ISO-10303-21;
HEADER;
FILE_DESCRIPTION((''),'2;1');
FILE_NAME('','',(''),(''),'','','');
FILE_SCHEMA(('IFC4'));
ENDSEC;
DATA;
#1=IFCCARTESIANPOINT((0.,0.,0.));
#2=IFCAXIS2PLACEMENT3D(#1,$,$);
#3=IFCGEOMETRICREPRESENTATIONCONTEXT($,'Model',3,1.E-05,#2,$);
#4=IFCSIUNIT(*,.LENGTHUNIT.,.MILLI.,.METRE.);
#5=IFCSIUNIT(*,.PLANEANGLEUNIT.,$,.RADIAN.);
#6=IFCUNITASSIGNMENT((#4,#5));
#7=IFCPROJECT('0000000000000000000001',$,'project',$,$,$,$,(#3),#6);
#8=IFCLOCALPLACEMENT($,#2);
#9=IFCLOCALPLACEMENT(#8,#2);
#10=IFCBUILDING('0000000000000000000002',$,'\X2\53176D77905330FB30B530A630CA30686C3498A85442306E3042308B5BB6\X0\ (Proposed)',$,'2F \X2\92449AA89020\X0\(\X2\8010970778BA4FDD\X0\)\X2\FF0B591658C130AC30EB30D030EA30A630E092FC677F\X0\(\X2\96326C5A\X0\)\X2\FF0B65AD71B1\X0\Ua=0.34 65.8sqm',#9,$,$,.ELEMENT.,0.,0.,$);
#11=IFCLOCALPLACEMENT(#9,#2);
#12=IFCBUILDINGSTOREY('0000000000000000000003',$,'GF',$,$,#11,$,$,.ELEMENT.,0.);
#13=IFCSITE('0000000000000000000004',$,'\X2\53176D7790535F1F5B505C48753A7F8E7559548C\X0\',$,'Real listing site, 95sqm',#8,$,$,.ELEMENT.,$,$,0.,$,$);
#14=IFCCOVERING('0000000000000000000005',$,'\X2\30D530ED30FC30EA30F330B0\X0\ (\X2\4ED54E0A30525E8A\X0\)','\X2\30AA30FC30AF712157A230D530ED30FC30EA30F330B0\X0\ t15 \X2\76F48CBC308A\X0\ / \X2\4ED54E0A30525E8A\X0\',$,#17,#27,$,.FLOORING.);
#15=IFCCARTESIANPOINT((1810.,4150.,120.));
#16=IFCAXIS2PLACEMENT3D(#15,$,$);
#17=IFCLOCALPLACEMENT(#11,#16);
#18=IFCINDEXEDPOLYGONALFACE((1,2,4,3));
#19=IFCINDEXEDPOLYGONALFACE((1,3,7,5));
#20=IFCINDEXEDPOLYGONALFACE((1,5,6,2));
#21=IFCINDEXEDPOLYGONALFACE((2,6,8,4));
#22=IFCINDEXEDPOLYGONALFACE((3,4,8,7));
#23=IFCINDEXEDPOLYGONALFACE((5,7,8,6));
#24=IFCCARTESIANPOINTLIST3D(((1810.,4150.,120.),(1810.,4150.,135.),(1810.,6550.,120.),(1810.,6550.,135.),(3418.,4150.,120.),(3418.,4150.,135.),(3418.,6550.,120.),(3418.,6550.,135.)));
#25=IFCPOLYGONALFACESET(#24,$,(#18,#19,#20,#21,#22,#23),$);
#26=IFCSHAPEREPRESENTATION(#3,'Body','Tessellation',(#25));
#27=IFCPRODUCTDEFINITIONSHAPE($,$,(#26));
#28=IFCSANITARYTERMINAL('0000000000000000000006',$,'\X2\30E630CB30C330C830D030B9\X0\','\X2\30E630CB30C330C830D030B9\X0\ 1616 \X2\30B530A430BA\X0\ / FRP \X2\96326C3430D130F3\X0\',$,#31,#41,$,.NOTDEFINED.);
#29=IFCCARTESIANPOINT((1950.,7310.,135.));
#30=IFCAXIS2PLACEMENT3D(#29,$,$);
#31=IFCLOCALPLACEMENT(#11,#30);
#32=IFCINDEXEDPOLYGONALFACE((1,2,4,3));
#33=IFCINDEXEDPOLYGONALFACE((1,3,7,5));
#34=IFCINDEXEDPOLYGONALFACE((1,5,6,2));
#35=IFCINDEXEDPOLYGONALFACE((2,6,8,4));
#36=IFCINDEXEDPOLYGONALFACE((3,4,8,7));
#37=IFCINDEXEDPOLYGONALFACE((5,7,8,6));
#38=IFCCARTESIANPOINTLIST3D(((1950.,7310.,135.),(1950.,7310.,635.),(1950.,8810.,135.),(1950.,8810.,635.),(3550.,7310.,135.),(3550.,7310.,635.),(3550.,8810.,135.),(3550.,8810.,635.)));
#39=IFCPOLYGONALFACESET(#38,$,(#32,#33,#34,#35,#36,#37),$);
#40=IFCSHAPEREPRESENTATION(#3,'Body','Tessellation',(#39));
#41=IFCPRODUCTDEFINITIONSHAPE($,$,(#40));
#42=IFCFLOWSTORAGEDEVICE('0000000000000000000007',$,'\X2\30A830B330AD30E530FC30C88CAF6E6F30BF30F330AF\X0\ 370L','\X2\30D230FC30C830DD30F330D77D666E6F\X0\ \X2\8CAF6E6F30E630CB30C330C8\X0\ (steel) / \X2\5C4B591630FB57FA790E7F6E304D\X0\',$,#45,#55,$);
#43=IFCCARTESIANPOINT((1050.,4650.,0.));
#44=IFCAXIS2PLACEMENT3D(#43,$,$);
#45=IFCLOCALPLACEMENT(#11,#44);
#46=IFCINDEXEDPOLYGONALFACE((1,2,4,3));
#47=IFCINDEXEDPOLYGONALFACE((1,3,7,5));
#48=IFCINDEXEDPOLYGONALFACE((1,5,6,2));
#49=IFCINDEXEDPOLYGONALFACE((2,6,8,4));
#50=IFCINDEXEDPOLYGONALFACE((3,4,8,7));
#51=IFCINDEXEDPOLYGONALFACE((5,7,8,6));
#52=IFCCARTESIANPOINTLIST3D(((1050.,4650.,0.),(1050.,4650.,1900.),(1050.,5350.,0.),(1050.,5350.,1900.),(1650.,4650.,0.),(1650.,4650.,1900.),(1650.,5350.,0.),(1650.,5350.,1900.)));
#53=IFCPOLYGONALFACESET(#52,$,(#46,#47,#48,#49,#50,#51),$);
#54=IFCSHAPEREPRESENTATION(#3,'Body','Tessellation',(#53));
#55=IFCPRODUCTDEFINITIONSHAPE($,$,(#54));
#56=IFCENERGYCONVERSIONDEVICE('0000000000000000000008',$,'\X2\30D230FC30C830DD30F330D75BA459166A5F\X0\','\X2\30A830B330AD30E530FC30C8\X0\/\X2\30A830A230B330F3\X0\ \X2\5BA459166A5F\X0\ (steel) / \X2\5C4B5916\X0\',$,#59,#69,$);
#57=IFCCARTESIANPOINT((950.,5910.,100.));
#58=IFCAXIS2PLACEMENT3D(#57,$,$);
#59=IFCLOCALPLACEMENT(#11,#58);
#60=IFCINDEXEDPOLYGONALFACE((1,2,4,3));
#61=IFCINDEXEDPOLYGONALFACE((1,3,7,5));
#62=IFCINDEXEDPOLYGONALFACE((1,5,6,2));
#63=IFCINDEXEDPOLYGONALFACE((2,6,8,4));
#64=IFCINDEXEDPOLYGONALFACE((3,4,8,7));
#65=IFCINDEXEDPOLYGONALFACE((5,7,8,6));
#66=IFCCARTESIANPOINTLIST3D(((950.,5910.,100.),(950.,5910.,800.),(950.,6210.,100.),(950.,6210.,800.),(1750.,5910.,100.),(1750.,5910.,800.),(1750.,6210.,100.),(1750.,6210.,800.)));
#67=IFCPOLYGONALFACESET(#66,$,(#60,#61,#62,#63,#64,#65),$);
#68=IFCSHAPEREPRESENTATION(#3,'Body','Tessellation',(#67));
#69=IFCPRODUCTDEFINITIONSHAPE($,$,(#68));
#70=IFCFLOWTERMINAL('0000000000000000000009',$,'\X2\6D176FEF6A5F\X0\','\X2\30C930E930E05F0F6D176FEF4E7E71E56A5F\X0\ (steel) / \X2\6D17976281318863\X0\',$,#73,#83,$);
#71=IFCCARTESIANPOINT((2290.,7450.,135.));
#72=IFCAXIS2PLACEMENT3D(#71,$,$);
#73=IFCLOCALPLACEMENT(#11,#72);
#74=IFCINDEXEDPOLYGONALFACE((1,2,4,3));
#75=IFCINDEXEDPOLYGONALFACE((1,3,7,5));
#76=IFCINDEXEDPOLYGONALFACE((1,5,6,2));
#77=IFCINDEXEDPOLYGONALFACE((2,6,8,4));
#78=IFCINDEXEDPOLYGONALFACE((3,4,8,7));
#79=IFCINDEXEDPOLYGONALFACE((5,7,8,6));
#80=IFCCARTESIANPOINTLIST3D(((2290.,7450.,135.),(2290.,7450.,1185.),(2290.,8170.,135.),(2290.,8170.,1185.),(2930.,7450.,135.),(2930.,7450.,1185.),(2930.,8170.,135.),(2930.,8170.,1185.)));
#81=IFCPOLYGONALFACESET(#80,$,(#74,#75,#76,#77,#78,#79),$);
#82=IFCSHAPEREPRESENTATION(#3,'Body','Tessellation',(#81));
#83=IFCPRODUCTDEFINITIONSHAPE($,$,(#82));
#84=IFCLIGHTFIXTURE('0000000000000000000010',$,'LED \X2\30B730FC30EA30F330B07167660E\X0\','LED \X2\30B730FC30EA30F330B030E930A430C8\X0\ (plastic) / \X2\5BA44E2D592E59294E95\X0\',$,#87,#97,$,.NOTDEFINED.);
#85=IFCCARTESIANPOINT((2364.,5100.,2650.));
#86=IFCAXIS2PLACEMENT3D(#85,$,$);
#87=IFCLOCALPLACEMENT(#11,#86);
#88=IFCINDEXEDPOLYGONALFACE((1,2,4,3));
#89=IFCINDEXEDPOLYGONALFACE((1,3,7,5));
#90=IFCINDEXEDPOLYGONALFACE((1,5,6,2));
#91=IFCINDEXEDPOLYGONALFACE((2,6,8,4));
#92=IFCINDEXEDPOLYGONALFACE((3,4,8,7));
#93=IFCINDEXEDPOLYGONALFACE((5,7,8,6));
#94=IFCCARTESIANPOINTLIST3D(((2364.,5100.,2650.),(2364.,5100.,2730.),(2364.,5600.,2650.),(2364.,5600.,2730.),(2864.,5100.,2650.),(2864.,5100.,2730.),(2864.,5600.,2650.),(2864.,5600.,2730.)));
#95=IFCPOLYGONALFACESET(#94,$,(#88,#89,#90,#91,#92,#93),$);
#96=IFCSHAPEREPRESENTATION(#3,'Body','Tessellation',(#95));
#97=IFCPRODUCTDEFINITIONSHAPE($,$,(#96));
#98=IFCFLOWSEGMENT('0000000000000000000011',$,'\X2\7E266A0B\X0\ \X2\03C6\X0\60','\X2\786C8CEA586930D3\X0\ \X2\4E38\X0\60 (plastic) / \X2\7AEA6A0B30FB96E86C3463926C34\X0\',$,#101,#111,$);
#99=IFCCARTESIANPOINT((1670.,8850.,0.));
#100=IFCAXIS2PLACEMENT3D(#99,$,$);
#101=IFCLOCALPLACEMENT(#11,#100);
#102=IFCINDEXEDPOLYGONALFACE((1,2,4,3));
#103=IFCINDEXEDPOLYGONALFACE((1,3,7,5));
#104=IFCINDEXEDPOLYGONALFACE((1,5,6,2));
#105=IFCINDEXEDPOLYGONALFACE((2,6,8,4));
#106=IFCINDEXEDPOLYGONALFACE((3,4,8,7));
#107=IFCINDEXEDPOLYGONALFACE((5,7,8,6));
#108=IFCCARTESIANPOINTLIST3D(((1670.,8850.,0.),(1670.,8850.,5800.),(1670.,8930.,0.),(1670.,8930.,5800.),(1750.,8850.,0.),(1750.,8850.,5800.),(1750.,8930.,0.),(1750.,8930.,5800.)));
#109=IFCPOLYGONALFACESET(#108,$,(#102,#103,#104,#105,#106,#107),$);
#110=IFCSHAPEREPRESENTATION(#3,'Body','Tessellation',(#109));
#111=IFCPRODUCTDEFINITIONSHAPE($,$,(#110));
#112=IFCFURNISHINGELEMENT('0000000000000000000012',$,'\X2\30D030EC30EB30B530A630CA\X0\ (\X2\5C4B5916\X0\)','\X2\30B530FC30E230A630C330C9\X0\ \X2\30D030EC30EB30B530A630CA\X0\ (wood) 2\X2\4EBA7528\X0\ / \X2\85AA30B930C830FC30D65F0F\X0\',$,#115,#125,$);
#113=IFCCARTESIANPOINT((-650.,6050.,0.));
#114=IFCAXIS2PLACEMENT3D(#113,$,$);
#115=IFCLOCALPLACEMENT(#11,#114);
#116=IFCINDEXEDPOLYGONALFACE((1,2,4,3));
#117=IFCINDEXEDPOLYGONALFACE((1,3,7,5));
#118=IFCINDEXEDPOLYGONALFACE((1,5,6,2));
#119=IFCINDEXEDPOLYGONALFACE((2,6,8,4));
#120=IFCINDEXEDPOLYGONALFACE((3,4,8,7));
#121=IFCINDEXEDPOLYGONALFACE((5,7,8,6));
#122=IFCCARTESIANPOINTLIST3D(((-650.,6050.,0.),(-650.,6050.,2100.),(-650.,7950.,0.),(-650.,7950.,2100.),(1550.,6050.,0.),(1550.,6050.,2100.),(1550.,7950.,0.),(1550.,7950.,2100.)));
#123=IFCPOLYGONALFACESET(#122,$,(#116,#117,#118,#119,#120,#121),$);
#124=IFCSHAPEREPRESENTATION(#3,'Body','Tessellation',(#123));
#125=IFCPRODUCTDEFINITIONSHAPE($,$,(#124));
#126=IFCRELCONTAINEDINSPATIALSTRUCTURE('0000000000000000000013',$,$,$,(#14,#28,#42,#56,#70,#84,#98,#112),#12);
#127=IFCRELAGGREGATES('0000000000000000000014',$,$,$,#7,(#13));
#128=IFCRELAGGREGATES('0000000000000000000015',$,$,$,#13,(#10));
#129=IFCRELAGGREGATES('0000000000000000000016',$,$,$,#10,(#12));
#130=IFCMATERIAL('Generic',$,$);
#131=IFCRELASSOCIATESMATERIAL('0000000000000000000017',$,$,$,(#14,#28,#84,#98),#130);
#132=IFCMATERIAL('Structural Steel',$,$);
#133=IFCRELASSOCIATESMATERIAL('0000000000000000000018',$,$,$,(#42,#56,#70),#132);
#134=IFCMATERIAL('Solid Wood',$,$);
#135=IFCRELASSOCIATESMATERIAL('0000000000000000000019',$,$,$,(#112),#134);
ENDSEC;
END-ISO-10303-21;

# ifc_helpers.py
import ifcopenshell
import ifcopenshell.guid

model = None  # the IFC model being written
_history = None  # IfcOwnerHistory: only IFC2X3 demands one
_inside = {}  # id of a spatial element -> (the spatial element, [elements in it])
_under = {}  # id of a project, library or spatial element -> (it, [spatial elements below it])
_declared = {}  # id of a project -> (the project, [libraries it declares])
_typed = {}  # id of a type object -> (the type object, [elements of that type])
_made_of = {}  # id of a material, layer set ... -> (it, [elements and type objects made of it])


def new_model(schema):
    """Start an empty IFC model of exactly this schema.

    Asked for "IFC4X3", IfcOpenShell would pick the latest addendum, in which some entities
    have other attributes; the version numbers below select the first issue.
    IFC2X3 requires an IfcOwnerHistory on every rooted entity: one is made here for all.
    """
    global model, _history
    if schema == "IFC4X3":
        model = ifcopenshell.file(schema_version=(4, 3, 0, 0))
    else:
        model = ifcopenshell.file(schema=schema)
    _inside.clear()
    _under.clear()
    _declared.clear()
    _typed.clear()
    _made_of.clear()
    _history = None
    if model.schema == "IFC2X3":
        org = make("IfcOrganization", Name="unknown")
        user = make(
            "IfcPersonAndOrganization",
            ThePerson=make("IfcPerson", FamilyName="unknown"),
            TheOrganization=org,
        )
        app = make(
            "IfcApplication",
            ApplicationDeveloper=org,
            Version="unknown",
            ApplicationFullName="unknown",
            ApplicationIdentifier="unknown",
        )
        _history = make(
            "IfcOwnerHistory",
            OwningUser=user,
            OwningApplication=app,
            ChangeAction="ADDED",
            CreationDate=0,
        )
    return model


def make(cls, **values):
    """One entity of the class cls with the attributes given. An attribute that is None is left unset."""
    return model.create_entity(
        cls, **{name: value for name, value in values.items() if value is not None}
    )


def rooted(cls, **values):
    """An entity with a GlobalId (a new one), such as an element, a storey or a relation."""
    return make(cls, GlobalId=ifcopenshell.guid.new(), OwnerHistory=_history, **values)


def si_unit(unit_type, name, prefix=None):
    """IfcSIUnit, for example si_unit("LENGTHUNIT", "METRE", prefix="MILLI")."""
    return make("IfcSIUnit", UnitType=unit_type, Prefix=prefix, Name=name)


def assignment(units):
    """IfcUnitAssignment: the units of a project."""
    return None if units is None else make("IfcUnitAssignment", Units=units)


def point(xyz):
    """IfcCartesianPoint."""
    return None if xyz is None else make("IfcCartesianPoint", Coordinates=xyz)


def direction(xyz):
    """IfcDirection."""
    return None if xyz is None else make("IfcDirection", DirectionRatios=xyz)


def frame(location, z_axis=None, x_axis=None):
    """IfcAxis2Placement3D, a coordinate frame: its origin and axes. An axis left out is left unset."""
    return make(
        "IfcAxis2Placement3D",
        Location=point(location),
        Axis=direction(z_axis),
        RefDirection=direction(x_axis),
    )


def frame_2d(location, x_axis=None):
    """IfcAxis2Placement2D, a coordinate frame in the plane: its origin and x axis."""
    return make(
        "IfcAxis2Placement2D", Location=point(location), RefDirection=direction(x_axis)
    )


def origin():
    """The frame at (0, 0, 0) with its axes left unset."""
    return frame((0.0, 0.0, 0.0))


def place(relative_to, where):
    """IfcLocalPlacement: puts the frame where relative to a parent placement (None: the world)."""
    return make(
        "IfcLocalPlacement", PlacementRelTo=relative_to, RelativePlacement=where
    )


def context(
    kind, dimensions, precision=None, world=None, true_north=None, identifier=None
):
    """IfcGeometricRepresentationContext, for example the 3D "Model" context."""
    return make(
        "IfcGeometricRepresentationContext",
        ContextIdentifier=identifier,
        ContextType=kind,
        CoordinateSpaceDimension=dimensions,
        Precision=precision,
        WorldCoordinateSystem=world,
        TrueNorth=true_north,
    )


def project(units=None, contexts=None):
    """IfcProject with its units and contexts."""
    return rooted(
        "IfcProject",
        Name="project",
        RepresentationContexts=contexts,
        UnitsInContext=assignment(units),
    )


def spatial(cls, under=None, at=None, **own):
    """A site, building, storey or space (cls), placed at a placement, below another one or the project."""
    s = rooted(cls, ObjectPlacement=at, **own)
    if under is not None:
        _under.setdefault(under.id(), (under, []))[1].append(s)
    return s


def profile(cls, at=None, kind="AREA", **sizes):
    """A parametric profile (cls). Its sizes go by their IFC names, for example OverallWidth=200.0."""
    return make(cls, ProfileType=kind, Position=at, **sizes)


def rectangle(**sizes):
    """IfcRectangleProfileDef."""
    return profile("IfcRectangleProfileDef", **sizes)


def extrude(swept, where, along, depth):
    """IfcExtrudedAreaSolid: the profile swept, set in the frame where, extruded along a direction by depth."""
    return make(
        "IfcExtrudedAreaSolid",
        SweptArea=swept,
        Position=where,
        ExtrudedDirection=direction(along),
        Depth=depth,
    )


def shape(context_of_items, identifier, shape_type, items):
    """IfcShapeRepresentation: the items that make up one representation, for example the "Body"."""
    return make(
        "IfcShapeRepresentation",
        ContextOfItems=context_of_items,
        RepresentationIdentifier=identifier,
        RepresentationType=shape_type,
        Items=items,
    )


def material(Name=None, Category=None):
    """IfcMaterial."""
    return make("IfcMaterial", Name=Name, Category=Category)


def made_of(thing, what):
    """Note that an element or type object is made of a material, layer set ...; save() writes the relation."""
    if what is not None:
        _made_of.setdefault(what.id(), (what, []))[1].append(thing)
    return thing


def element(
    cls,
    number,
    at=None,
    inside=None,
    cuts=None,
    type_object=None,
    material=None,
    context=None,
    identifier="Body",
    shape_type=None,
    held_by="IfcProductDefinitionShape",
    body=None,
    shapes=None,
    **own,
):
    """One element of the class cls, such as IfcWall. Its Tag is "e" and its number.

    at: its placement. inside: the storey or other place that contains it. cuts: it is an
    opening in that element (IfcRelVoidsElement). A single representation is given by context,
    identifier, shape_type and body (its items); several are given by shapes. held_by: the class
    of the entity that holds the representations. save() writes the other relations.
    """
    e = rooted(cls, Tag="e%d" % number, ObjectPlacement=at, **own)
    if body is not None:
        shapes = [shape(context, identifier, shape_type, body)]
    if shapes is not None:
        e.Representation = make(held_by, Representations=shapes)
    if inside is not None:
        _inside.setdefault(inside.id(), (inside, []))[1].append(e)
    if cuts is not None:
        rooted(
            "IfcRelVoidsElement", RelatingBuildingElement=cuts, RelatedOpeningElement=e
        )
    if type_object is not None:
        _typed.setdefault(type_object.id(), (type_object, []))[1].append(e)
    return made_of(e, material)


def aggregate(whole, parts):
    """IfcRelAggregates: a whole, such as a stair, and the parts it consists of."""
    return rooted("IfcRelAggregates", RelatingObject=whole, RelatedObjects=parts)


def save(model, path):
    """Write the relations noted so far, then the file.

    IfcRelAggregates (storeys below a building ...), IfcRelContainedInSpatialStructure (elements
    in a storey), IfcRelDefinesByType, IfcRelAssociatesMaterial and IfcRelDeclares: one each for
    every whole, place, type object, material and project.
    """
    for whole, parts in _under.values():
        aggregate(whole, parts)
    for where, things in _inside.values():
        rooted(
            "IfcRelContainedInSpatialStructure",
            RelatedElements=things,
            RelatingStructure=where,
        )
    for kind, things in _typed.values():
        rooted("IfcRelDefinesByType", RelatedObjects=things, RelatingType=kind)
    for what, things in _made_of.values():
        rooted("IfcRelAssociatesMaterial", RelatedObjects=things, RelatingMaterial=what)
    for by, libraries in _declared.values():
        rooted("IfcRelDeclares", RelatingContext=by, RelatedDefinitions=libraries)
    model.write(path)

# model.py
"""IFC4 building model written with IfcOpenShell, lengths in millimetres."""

from ifc_helpers import new_model, si_unit, frame, frame_2d, origin, place, context, project, spatial, rectangle, extrude, material, element, save


model = new_model("IFC4")

# Units and contexts
model_context = context("Model", 3, precision=1e-05, world=origin())
ifc_project = project(units=[si_unit("LENGTHUNIT", "METRE", prefix="MILLI"), si_unit("PLANEANGLEUNIT", "RADIAN")], contexts=[model_context])

# Site, building, storey
site_placement = place(None, origin())
site = spatial("IfcSite", under=ifc_project, at=site_placement, Name="北海道弟子屈町美留和", ObjectType="Real listing site, 95sqm", CompositionType="ELEMENT", RefElevation=0.0)
building_placement = place(site_placement, origin())
building = spatial("IfcBuilding", under=site, at=building_placement, Name="北海道・サウナと水風呂のある家 (Proposed)", ObjectType="2F 鉄骨造(耐震確保)＋外壁ガルバリウム鋼板(防汚)＋断熱Ua=0.34 65.8sqm", CompositionType="ELEMENT", ElevationOfRefHeight=0.0, ElevationOfTerrain=0.0)
storey_placement = place(building_placement, origin())
storey = spatial("IfcBuildingStorey", under=building, at=storey_placement, Name="GF", CompositionType="ELEMENT", Elevation=0.0)

# Shared definitions
ifc_material_1 = material(Name="Solid Wood")

# Covering
ifc_material_2 = material(Name="Generic")
covering_1_placement = place(storey_placement, frame((1810.0, 4150.0, 120.0)))
element("IfcCovering", 1, at=covering_1_placement, inside=storey, material=ifc_material_2, Name="フローリング (仕上げ床)", Description="オーク無垢フローリング t15 直貼り / 仕上げ床", PredefinedType="FLOORING", context=model_context, shape_type="SweptSolid", body=[
    extrude(rectangle(XDim=1608.0, YDim=2400.0, at=frame_2d((804.0, 1200.0))), frame((1810.0, 4150.0, 120.0)), (0.0, 0.0, 1.0), 15.0),
])

# Sanitary terminal
sanitary_terminal_placement = place(storey_placement, frame((1950.0, 7310.0, 135.0)))
element("IfcSanitaryTerminal", 2, at=sanitary_terminal_placement, inside=storey, material=ifc_material_2, Name="ユニットバス", Description="ユニットバス 1616 サイズ / FRP 防水パン", PredefinedType="NOTDEFINED", context=model_context, shape_type="SweptSolid", body=[
    extrude(rectangle(XDim=1600.0, YDim=1500.0, at=frame_2d((800.0, 750.0))), frame((1950.0, 7310.0, 135.0)), (0.0, 0.0, 1.0), 500.0),
])

# Flow storage device
ifc_material_3 = material(Name="Structural Steel")
flow_storage_device_placement = place(storey_placement, frame((1050.0, 4650.0, 0.0)))
element("IfcFlowStorageDevice", 3, at=flow_storage_device_placement, inside=storey, material=ifc_material_3, Name="エコキュート貯湯タンク 370L", Description="ヒートポンプ給湯 貯湯ユニット (steel) / 屋外・基礎置き", context=model_context, shape_type="SweptSolid", body=[
    extrude(rectangle(XDim=600.0, YDim=700.0, at=frame_2d((300.0, 350.0))), frame((1050.0, 4650.0, 0.0)), (0.0, 0.0, 1.0), 1900.0),
])

# Energy conversion device
energy_conversion_device_placement = place(storey_placement, frame((950.0, 5910.0, 100.0)))
element("IfcEnergyConversionDevice", 4, at=energy_conversion_device_placement, inside=storey, material=ifc_material_3, Name="ヒートポンプ室外機", Description="エコキュート/エアコン 室外機 (steel) / 屋外", context=model_context, shape_type="SweptSolid", body=[
    extrude(rectangle(XDim=800.0, YDim=300.0, at=frame_2d((400.0, 150.0))), frame((950.0, 5910.0, 100.0)), (0.0, 0.0, 1.0), 700.0),
])

# Flow terminal
flow_terminal_placement = place(storey_placement, frame((2290.0, 7450.0, 135.0)))
element("IfcFlowTerminal", 5, at=flow_terminal_placement, inside=storey, material=ifc_material_3, Name="洗濯機", Description="ドラム式洗濯乾燥機 (steel) / 洗面脱衣", context=model_context, shape_type="SweptSolid", body=[
    extrude(rectangle(XDim=640.0, YDim=720.0, at=frame_2d((320.0, 360.0))), frame((2290.0, 7450.0, 135.0)), (0.0, 0.0, 1.0), 1050.0),
])

# Light fixture
light_fixture_placement = place(storey_placement, frame((2364.0, 5100.0, 2650.0)))
element("IfcLightFixture", 6, at=light_fixture_placement, inside=storey, material=ifc_material_2, Name="LED シーリング照明", Description="LED シーリングライト (plastic) / 室中央天井", PredefinedType="NOTDEFINED", context=model_context, shape_type="SweptSolid", body=[
    extrude(rectangle(XDim=500.0, YDim=500.0, at=frame_2d((250.0, 250.0))), frame((2364.0, 5100.0, 2650.0)), (0.0, 0.0, 1.0), 80.0),
])

# Flow segment
flow_segment_placement = place(storey_placement, frame((1670.0, 8850.0, 0.0)))
element("IfcFlowSegment", 7, at=flow_segment_placement, inside=storey, material=ifc_material_2, Name="縦樋 φ60", Description="硬質塩ビ 丸60 (plastic) / 竪樋・雨水排水", context=model_context, shape_type="SweptSolid", body=[
    extrude(rectangle(XDim=80.0, YDim=80.0, at=frame_2d((40.0, 40.0))), frame((1670.0, 8850.0, 0.0)), (0.0, 0.0, 1.0), 5800.0),
])

# Furnishing element
furnishing_placement = place(storey_placement, frame((-650.0, 6050.0, 0.0)))
element("IfcFurnishingElement", 8, at=furnishing_placement, inside=storey, material=ifc_material_1, Name="バレルサウナ (屋外)", Description="サーモウッド バレルサウナ (wood) 2人用 / 薪ストーブ式", context=model_context, shape_type="SweptSolid", body=[
    extrude(rectangle(XDim=2200.0, YDim=1900.0, at=frame_2d((1100.0, 950.0))), frame((-650.0, 6050.0, 0.0)), (0.0, 0.0, 1.0), 2100.0),
])

save(model, "model.ifc")
